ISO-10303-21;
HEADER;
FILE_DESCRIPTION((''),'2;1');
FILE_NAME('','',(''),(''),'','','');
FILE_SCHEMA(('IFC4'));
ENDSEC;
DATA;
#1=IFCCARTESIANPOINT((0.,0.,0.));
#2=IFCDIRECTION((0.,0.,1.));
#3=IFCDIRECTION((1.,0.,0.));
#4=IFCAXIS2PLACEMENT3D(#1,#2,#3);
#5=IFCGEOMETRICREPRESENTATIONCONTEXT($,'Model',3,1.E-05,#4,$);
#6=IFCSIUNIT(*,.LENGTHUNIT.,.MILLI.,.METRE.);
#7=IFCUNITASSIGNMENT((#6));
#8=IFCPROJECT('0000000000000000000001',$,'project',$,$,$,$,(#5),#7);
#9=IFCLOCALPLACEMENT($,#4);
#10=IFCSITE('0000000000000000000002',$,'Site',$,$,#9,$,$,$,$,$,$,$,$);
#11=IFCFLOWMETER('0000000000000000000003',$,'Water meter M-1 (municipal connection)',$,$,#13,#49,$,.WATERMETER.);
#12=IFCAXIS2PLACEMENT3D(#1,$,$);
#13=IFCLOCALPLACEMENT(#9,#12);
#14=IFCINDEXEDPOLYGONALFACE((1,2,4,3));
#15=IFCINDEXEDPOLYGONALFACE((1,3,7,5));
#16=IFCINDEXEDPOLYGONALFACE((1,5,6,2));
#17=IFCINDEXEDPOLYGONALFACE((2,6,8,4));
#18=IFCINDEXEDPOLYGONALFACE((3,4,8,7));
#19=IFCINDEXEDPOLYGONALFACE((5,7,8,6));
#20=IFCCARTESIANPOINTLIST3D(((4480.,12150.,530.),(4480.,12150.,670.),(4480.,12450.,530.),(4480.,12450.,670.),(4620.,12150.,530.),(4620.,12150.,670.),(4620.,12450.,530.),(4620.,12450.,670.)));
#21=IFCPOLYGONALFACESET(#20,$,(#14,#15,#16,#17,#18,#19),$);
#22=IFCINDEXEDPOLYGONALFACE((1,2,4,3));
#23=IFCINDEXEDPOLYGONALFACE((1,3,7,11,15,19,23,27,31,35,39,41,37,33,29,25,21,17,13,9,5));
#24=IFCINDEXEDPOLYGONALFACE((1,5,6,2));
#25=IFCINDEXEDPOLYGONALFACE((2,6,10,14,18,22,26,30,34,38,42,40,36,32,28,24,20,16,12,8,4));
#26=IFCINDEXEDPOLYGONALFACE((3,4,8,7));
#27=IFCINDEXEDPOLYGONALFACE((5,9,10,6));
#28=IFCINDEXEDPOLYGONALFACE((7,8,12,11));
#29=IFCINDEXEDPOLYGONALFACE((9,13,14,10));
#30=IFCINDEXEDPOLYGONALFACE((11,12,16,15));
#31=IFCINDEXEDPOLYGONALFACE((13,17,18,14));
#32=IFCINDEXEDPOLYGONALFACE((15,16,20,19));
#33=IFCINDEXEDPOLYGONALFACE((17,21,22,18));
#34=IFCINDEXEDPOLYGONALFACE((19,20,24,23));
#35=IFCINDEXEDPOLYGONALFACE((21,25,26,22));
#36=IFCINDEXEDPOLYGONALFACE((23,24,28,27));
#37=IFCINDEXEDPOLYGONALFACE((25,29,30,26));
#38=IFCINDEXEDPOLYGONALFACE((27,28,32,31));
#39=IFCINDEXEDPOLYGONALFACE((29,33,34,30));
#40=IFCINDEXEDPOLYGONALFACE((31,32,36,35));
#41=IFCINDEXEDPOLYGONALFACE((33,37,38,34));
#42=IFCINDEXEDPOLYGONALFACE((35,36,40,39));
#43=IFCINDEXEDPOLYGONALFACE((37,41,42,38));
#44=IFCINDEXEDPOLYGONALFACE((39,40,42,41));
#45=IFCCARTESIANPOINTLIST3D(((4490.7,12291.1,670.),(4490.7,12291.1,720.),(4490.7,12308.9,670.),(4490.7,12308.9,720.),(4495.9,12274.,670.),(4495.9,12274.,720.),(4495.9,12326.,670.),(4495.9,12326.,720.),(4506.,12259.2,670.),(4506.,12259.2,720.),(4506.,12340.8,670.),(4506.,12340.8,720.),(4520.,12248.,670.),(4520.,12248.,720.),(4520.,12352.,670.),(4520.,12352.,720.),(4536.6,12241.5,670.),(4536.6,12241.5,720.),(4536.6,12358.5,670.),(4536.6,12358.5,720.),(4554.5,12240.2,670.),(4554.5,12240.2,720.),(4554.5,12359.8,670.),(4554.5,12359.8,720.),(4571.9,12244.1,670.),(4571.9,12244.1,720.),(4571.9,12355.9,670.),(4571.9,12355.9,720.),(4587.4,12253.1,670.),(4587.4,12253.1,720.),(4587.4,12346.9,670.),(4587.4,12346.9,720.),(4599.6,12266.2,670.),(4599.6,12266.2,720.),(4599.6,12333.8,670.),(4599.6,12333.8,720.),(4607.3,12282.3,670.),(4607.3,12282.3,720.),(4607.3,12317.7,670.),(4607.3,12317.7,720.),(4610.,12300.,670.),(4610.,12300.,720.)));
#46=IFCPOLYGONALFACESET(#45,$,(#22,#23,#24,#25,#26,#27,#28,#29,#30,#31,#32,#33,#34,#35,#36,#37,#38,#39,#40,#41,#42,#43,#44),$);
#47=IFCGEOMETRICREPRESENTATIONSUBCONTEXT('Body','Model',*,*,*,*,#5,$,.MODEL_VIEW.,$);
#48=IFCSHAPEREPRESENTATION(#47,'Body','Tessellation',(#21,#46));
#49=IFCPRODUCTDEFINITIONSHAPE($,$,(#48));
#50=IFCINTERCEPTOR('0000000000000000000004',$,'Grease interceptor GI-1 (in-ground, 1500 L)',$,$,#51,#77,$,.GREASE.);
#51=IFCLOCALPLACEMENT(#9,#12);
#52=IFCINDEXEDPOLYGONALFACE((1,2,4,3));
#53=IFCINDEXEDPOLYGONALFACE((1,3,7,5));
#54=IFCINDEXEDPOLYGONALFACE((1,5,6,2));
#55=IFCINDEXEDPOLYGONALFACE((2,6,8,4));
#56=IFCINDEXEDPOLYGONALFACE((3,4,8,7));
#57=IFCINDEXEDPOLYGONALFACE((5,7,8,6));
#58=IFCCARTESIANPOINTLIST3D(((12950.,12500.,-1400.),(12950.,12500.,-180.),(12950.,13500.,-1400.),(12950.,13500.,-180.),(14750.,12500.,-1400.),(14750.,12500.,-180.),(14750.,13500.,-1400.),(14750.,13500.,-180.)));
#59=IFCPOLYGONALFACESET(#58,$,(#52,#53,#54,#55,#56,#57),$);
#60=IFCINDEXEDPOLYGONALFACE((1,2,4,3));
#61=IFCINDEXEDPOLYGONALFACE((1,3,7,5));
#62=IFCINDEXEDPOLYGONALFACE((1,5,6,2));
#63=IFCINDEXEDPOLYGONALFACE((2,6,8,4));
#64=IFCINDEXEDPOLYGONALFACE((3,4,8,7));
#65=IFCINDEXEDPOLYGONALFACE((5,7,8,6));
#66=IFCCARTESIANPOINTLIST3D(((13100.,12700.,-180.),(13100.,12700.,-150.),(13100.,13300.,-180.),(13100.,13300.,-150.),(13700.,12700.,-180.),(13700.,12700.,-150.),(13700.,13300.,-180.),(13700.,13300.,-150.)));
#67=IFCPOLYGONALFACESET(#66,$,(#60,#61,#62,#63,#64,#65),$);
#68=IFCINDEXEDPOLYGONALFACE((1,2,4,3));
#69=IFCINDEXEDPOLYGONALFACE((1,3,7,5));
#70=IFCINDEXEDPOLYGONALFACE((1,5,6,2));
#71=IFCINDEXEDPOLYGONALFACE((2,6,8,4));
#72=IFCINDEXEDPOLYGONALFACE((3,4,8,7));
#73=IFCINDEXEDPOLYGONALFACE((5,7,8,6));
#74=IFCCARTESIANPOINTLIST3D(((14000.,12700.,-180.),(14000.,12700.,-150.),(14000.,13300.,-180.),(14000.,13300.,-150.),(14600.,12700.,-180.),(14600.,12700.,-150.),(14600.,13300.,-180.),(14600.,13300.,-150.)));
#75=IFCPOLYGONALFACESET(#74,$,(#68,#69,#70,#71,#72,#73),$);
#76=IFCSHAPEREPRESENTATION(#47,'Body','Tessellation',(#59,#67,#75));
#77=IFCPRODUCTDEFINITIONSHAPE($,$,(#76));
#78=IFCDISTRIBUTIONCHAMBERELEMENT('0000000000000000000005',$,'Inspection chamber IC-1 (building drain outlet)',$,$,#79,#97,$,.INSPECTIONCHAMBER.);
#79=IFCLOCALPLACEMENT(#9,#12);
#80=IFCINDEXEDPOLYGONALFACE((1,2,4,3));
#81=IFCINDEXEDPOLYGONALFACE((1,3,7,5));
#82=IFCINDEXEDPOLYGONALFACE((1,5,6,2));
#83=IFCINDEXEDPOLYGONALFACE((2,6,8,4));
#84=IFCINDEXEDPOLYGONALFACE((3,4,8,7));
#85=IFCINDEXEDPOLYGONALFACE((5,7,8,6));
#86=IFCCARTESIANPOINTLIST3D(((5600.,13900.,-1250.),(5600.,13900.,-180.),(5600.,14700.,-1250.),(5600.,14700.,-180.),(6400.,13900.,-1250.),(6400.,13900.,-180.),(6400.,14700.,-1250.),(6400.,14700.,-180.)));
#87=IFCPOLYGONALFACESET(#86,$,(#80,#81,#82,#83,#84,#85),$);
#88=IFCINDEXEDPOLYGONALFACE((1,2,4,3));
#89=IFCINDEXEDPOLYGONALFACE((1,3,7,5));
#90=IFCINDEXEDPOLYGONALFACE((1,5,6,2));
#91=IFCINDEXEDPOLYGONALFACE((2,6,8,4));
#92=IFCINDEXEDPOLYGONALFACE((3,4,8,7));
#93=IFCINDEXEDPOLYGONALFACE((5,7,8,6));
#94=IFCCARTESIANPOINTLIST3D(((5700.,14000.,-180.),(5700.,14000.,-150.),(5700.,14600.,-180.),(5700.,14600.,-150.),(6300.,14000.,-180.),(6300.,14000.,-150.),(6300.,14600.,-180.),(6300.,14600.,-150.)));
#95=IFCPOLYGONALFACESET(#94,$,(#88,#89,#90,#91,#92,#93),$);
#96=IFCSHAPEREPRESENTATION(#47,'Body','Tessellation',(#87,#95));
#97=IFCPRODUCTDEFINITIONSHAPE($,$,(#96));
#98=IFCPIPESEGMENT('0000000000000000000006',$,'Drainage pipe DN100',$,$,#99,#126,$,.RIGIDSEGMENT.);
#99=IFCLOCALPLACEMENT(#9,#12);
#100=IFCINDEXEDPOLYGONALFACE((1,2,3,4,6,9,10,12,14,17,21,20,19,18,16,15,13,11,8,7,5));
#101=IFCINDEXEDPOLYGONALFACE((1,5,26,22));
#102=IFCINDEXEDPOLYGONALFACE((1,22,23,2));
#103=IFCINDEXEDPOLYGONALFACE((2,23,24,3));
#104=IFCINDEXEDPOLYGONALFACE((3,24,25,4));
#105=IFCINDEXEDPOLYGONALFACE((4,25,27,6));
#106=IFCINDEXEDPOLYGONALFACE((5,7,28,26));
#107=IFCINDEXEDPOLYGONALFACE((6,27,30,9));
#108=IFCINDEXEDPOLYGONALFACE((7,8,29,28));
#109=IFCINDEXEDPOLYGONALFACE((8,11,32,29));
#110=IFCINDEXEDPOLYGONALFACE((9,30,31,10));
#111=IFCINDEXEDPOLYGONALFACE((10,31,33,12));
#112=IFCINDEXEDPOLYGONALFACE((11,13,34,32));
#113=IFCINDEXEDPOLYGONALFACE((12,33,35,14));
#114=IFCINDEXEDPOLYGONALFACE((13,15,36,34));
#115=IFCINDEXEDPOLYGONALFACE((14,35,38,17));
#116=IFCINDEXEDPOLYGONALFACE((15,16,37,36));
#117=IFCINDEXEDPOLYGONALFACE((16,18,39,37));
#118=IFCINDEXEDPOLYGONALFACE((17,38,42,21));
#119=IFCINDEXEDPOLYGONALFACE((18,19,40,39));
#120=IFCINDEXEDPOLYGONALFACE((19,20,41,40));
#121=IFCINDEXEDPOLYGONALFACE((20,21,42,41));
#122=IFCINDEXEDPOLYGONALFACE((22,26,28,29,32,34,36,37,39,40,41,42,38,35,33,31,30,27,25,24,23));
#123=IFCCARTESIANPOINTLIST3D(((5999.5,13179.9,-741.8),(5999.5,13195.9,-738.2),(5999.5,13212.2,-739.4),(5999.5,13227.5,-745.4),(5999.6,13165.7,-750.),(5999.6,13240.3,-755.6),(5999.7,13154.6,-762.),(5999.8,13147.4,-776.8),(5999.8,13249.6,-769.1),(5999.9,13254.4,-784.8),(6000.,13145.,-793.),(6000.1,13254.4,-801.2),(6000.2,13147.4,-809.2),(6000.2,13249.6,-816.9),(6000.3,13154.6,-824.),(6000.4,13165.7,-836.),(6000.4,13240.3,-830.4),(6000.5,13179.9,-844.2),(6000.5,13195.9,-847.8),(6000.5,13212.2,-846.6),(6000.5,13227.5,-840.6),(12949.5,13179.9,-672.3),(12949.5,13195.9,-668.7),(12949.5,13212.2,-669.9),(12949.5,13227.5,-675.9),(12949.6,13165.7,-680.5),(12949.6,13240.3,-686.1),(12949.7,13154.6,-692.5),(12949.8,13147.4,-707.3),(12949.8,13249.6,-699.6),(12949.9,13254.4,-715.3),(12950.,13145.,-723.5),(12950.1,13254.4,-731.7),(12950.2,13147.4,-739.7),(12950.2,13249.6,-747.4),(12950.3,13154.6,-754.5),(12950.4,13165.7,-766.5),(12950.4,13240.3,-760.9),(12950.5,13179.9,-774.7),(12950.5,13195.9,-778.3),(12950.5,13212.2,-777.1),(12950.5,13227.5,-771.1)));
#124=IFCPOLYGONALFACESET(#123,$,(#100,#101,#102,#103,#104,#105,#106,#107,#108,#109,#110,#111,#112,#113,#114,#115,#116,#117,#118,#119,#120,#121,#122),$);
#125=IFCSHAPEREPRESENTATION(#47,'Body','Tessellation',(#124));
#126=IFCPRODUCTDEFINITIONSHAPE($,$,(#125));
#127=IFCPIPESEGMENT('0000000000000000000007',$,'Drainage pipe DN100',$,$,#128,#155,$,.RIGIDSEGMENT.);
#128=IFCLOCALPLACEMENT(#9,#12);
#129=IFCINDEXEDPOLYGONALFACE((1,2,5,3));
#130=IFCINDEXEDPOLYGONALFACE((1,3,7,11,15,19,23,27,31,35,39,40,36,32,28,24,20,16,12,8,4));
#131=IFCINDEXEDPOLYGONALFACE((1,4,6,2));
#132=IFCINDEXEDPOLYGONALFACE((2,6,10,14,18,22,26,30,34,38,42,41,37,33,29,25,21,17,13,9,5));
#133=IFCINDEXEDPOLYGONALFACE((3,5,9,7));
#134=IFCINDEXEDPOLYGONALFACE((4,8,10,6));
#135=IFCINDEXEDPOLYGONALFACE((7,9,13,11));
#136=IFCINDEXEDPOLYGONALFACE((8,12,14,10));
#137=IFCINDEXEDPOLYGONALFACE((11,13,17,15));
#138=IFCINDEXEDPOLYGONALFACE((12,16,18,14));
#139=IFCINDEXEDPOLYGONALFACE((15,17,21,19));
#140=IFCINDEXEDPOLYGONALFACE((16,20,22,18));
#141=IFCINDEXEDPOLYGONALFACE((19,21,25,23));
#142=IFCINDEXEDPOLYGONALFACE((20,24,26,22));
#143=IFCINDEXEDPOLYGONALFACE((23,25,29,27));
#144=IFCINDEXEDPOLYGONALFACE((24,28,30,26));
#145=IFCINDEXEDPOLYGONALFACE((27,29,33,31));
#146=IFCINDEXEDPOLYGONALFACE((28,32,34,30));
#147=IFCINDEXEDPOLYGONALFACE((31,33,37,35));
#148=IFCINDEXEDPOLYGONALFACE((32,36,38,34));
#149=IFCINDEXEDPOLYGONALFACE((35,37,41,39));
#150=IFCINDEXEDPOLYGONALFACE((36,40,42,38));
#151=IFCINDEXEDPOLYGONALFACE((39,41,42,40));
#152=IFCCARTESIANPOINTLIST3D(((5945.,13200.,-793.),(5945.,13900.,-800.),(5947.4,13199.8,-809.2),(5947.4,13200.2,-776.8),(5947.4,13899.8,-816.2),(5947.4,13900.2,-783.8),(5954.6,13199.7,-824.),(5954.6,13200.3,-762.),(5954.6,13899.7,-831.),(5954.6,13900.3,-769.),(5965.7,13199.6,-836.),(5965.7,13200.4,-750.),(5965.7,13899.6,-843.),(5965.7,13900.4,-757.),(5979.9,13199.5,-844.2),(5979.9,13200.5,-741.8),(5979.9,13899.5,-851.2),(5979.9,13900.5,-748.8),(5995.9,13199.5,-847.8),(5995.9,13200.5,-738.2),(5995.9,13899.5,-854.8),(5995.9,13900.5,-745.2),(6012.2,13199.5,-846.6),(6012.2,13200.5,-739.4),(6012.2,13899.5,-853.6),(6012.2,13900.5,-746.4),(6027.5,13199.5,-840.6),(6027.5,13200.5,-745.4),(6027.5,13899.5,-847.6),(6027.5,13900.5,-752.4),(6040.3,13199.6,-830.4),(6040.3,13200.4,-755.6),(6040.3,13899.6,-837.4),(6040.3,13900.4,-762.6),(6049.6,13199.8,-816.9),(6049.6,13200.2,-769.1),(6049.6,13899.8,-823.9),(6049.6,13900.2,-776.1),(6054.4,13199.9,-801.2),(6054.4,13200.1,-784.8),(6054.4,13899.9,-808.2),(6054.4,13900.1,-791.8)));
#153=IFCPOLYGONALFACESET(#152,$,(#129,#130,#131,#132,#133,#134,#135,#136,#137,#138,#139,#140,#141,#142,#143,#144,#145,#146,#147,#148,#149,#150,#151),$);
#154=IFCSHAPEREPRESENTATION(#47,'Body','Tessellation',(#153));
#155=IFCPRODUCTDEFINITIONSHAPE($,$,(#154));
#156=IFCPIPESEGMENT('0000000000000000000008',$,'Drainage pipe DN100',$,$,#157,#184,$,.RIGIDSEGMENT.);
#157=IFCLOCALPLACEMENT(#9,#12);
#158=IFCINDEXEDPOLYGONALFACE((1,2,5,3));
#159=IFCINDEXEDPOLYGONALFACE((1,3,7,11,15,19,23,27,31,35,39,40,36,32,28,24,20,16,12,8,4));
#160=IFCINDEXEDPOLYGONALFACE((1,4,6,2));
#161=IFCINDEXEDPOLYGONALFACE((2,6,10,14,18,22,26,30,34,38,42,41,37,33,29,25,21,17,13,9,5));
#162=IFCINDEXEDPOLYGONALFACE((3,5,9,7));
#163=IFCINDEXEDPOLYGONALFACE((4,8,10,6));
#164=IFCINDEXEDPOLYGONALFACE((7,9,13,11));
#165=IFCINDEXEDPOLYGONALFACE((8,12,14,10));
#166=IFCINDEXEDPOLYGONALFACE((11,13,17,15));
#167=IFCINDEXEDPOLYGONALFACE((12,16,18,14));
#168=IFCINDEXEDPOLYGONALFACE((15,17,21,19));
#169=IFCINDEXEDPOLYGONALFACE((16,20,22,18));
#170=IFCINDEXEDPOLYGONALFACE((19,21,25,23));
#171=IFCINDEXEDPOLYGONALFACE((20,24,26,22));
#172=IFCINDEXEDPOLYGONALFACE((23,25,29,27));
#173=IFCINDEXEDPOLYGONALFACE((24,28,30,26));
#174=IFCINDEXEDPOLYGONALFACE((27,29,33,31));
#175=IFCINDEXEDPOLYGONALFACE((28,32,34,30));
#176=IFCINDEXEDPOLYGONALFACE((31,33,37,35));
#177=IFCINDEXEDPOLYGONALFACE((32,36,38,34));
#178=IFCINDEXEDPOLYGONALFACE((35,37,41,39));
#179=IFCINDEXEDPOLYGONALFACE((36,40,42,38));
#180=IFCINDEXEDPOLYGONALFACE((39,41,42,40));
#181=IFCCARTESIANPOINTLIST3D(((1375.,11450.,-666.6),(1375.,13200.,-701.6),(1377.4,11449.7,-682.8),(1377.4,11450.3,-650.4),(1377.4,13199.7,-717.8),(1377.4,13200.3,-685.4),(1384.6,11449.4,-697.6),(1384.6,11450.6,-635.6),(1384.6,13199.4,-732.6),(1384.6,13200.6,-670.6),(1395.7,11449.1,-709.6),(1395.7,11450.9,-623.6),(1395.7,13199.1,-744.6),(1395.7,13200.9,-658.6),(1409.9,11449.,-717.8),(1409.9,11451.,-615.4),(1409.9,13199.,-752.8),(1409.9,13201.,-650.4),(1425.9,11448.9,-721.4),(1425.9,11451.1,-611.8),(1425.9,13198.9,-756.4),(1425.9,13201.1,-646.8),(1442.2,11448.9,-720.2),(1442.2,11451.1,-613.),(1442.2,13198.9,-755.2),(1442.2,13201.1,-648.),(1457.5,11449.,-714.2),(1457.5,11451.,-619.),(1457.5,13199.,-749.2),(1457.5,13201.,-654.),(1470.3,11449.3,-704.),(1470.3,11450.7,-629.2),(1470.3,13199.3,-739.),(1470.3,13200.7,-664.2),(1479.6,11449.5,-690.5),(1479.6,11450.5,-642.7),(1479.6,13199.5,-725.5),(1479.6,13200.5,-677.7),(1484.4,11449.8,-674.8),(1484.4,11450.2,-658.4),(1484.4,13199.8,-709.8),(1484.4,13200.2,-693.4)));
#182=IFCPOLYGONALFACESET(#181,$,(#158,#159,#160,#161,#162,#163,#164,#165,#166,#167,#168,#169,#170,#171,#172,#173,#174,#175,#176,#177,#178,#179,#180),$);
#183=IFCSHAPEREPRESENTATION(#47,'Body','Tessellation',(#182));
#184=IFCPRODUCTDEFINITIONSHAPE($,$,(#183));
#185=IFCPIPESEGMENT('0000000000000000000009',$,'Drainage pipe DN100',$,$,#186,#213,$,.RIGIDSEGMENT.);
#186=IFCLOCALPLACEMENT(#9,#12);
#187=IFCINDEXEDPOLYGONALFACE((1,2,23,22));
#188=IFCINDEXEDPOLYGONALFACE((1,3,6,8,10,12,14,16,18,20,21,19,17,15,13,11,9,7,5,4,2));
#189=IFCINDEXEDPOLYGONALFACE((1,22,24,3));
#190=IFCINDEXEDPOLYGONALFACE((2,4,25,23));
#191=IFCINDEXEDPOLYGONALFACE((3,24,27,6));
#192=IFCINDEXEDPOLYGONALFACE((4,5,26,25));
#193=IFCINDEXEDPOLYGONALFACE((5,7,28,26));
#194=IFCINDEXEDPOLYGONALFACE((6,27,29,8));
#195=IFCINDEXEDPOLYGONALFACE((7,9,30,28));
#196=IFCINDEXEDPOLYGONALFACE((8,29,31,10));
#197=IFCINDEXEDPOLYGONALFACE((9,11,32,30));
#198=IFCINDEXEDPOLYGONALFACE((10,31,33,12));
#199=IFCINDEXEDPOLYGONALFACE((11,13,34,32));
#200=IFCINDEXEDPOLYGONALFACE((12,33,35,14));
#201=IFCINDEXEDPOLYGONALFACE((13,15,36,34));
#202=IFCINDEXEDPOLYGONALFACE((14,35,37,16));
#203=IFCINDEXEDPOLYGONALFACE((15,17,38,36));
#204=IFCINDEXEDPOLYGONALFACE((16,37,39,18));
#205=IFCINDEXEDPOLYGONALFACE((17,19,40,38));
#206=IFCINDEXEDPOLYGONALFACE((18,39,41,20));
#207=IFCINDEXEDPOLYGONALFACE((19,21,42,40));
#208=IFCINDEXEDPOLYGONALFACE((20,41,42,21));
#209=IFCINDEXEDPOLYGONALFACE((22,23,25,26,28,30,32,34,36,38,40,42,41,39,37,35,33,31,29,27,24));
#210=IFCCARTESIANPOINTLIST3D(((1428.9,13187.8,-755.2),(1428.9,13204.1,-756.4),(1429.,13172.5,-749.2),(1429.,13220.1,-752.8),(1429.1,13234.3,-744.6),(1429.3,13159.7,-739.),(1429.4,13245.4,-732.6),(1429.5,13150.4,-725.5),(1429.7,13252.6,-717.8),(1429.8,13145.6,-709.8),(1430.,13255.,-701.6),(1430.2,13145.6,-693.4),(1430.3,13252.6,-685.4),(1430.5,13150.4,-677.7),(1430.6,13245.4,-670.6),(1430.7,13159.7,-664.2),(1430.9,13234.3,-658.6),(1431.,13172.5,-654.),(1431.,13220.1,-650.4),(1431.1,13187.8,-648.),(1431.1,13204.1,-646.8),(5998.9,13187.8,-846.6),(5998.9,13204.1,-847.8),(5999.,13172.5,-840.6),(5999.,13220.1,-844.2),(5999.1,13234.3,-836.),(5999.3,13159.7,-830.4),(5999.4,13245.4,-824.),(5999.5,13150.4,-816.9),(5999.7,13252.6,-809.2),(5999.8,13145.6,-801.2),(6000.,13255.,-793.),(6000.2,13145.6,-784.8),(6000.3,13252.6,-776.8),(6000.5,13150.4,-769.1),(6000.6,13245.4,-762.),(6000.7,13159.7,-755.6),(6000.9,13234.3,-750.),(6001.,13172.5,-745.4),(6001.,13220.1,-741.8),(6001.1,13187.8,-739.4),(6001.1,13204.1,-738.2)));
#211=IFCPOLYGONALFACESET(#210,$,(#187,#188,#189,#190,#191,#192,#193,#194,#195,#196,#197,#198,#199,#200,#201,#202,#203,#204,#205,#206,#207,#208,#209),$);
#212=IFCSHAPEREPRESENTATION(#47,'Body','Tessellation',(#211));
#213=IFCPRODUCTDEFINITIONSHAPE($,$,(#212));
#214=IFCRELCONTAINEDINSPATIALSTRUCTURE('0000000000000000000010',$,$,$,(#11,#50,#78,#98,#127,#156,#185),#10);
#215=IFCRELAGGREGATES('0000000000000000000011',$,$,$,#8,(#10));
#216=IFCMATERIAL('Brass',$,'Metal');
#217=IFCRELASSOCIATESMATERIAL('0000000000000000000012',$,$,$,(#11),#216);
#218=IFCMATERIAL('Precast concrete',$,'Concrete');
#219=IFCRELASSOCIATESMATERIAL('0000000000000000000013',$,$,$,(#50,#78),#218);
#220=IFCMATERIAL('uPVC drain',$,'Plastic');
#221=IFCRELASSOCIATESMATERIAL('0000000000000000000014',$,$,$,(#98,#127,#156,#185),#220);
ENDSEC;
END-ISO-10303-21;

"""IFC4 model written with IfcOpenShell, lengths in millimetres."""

from ifc_helpers import new_model, si_unit, frame, origin_with_axes, origin_2d, place, context, subcontext, project, spatial, rectangle, circle, extrude, material, element, save


model = new_model("IFC4")

# Units and contexts
model_context = context("Model", 3, precision=1e-05, world=origin_with_axes())
body_context = subcontext(model_context, "Body", "Model", "MODEL_VIEW")
ifc_project = project(units=[si_unit("LENGTHUNIT", "METRE", prefix="MILLI")], contexts=[model_context])

# Site
site_placement = place(None, origin_with_axes())
site = spatial("IfcSite", under=ifc_project, at=site_placement, Name="Site")

# Flow meter
ifc_material_1 = material(Name="Brass", Category="Metal")
placement_1 = place(site_placement, origin_with_axes())
placement_2 = place(placement_1, origin_with_axes())
flow_meter_placement = place(placement_2, frame((4550.0, 12300.0, 0.0)))
element("IfcFlowMeter", 1, at=flow_meter_placement, inside=site, material=ifc_material_1, Name="Water meter M-1 (municipal connection)", PredefinedType="WATERMETER", context=body_context, shape_type="SweptSolid", body=[
    extrude(rectangle(XDim=140.0, YDim=300.0, at=origin_2d()), frame((0.0, 0.0, 530.0)), (0.0, 0.0, 1.0), 140.0),
    extrude(circle(Radius=60.0, at=origin_2d()), frame((0.0, 0.0, 670.0)), (0.0, 0.0, 1.0), 50.0),
])

# Interceptor
ifc_material_2 = material(Name="Precast concrete", Category="Concrete")
interceptor_placement = place(placement_2, frame((13850.0, 13000.0, 0.0)))
element("IfcInterceptor", 2, at=interceptor_placement, inside=site, material=ifc_material_2, Name="Grease interceptor GI-1 (in-ground, 1500 L)", PredefinedType="GREASE", context=body_context, shape_type="SweptSolid", body=[
    extrude(rectangle(XDim=1800.0, YDim=1000.0, at=origin_2d()), frame((0.0, 0.0, -1400.0)), (0.0, 0.0, 1.0), 1220.0),
    extrude(rectangle(XDim=600.0, YDim=600.0, at=origin_2d()), frame((-450.0, 0.0, -180.0)), (0.0, 0.0, 1.0), 30.0),
    extrude(rectangle(XDim=600.0, YDim=600.0, at=origin_2d()), frame((450.0, 0.0, -180.0)), (0.0, 0.0, 1.0), 30.0),
])

# Distribution chamber element
distribution_chamber_element_placement = place(placement_2, frame((6000.0, 14300.0, 0.0)))
element("IfcDistributionChamberElement", 3, at=distribution_chamber_element_placement, inside=site, material=ifc_material_2, Name="Inspection chamber IC-1 (building drain outlet)", PredefinedType="INSPECTIONCHAMBER", context=body_context, shape_type="SweptSolid", body=[
    extrude(rectangle(XDim=800.0, YDim=800.0, at=origin_2d()), frame((0.0, 0.0, -1250.0)), (0.0, 0.0, 1.0), 1070.0),
    extrude(rectangle(XDim=600.0, YDim=600.0, at=origin_2d()), frame((0.0, 0.0, -180.0)), (0.0, 0.0, 1.0), 30.0),
])

# Pipe segments
ifc_material_3 = material(Name="uPVC drain", Category="Plastic")
pipe_segment_1_placement = place(placement_2, frame((12950.0, 13200.0, -723.5)))
element("IfcPipeSegment", 4, at=pipe_segment_1_placement, inside=site, material=ifc_material_3, Name="Drainage pipe DN100", PredefinedType="RIGIDSEGMENT", context=body_context, shape_type="SweptSolid", body=[
    extrude(circle(Radius=55.0, at=origin_2d()), frame((0.0, 0.0, 0.0), z_axis=(-0.99995, 0.0, -0.009999), x_axis=(0.0, -1.0, 0.0)), (0.0, 0.0, 1.0), 6950.3),
])
pipe_segment_2_placement = place(placement_2, frame((6000.0, 13200.0, -793.0)))
element("IfcPipeSegment", 5, at=pipe_segment_2_placement, inside=site, material=ifc_material_3, Name="Drainage pipe DN100", PredefinedType="RIGIDSEGMENT", context=body_context, shape_type="SweptSolid", body=[
    extrude(circle(Radius=55.0, at=origin_2d()), frame((0.0, 0.0, 0.0), z_axis=(0.0, 0.99995, -0.009999), x_axis=(-1.0, 0.0, 0.0)), (0.0, 0.0, 1.0), 700.0),
])
pipe_segment_3_placement = place(placement_2, frame((1430.0, 11450.0, -666.6)))
element("IfcPipeSegment", 6, at=pipe_segment_3_placement, inside=site, material=ifc_material_3, Name="Drainage pipe DN100", PredefinedType="RIGIDSEGMENT", context=body_context, shape_type="SweptSolid", body=[
    extrude(circle(Radius=55.0, at=origin_2d()), frame((0.0, 0.0, 0.0), z_axis=(0.0, 0.9998, -0.019996), x_axis=(-1.0, 0.0, 0.0)), (0.0, 0.0, 1.0), 1750.3),
])
pipe_segment_4_placement = place(placement_2, frame((1430.0, 13200.0, -701.6)))
element("IfcPipeSegment", 7, at=pipe_segment_4_placement, inside=site, material=ifc_material_3, Name="Drainage pipe DN100", PredefinedType="RIGIDSEGMENT", context=body_context, shape_type="SweptSolid", body=[
    extrude(circle(Radius=55.0, at=origin_2d()), frame((0.0, 0.0, 0.0), z_axis=(0.9998, 0.0, -0.019996), x_axis=(0.0, 1.0, 0.0)), (0.0, 0.0, 1.0), 4570.9),
])

save(model, "model.ifc")
